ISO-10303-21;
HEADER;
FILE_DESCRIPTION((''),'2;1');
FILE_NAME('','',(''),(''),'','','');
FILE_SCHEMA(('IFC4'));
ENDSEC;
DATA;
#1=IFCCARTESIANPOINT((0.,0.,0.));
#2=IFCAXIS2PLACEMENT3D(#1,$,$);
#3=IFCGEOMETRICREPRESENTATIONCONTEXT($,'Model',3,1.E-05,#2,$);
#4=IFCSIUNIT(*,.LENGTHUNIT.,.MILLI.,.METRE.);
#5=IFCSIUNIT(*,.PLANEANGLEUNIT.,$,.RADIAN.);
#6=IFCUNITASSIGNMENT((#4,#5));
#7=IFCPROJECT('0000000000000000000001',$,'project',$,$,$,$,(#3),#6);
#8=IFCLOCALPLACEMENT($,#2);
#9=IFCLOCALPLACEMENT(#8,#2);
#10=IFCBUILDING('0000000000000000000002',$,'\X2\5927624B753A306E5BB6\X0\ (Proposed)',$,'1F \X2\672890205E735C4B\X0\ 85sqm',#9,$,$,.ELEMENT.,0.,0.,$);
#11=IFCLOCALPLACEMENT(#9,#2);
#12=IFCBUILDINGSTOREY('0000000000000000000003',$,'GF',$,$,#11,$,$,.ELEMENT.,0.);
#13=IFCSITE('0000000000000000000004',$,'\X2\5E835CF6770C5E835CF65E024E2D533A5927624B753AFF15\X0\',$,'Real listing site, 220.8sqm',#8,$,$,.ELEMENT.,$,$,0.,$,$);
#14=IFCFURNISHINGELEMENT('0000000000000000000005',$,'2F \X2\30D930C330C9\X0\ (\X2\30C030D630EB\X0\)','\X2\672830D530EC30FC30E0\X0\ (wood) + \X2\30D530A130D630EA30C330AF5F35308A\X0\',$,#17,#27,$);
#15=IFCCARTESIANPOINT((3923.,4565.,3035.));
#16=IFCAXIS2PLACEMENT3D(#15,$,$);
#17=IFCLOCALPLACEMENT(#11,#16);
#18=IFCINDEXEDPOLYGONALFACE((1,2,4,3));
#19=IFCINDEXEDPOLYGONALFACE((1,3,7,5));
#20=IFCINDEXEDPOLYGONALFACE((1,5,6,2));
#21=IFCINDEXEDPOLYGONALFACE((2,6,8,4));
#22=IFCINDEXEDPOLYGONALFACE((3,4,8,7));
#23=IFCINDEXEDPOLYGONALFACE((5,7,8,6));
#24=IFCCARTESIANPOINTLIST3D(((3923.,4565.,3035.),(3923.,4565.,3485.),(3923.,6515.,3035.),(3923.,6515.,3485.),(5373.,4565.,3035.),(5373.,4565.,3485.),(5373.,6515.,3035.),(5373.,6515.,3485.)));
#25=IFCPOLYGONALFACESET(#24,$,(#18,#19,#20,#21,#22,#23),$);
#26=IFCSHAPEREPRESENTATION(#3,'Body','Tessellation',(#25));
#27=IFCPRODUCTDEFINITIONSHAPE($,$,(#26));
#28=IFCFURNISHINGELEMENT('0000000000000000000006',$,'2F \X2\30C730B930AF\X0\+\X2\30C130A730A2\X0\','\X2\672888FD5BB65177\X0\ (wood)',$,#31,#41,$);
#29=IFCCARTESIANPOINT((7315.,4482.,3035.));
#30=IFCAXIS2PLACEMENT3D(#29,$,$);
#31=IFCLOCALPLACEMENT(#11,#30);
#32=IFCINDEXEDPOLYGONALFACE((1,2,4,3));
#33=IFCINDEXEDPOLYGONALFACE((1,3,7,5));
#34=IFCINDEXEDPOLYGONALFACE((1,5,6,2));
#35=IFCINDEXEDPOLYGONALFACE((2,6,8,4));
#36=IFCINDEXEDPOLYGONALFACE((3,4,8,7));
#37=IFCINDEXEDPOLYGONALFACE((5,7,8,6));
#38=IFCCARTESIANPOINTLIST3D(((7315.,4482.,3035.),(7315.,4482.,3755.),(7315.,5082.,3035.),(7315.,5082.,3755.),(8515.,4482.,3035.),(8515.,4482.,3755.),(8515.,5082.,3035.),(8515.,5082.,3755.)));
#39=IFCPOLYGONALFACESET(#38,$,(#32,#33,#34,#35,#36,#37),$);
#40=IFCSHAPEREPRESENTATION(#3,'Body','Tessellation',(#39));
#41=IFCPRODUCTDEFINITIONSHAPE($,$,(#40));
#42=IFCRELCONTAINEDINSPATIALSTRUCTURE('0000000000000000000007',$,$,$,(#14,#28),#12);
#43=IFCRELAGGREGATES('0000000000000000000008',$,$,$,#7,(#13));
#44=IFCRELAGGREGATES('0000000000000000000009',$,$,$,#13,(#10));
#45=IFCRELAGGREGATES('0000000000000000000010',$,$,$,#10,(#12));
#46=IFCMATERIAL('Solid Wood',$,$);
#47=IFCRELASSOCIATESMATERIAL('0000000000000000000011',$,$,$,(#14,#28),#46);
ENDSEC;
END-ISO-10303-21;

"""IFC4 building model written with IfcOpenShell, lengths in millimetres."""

from ifc_helpers import new_model, si_unit, frame, frame_2d, origin, place, context, project, spatial, rectangle, extrude, material, element, save


model = new_model("IFC4")

# Units and contexts
model_context = context("Model", 3, precision=1e-05, world=origin())
ifc_project = project(units=[si_unit("LENGTHUNIT", "METRE", prefix="MILLI"), si_unit("PLANEANGLEUNIT", "RADIAN")], contexts=[model_context])

# Site, building, storey
site_placement = place(None, origin())
site = spatial("IfcSite", under=ifc_project, at=site_placement, Name="広島県広島市中区大手町５", ObjectType="Real listing site, 220.8sqm", CompositionType="ELEMENT", RefElevation=0.0)
building_placement = place(site_placement, origin())
building = spatial("IfcBuilding", under=site, at=building_placement, Name="大手町の家 (Proposed)", ObjectType="1F 木造平屋 85sqm", CompositionType="ELEMENT", ElevationOfRefHeight=0.0, ElevationOfTerrain=0.0)
storey_placement = place(building_placement, origin())
storey = spatial("IfcBuildingStorey", under=building, at=storey_placement, Name="GF", CompositionType="ELEMENT", Elevation=0.0)

# Shared definitions
ifc_material_1 = material(Name="Solid Wood")

# Furnishing elements
furnishing_1_placement = place(storey_placement, frame((3923.0, 4565.0, 3035.0)))
element("IfcFurnishingElement", 1, at=furnishing_1_placement, inside=storey, material=ifc_material_1, Name="2F ベッド (ダブル)", Description="木フレーム (wood) + ファブリック張り", context=model_context, shape_type="SweptSolid", body=[
    extrude(rectangle(XDim=1450.0, YDim=1950.0, at=frame_2d((725.0, 975.0))), frame((3923.0, 4565.0, 3035.0)), (0.0, 0.0, 1.0), 450.0),
])
furnishing_2_placement = place(storey_placement, frame((7315.0, 4482.0, 3035.0)))
element("IfcFurnishingElement", 2, at=furnishing_2_placement, inside=storey, material=ifc_material_1, Name="2F デスク+チェア", Description="木製家具 (wood)", context=model_context, shape_type="SweptSolid", body=[
    extrude(rectangle(XDim=1200.0, YDim=600.0, at=frame_2d((600.0, 300.0))), frame((7315.0, 4482.0, 3035.0)), (0.0, 0.0, 1.0), 720.0),
])

save(model, "model.ifc")
